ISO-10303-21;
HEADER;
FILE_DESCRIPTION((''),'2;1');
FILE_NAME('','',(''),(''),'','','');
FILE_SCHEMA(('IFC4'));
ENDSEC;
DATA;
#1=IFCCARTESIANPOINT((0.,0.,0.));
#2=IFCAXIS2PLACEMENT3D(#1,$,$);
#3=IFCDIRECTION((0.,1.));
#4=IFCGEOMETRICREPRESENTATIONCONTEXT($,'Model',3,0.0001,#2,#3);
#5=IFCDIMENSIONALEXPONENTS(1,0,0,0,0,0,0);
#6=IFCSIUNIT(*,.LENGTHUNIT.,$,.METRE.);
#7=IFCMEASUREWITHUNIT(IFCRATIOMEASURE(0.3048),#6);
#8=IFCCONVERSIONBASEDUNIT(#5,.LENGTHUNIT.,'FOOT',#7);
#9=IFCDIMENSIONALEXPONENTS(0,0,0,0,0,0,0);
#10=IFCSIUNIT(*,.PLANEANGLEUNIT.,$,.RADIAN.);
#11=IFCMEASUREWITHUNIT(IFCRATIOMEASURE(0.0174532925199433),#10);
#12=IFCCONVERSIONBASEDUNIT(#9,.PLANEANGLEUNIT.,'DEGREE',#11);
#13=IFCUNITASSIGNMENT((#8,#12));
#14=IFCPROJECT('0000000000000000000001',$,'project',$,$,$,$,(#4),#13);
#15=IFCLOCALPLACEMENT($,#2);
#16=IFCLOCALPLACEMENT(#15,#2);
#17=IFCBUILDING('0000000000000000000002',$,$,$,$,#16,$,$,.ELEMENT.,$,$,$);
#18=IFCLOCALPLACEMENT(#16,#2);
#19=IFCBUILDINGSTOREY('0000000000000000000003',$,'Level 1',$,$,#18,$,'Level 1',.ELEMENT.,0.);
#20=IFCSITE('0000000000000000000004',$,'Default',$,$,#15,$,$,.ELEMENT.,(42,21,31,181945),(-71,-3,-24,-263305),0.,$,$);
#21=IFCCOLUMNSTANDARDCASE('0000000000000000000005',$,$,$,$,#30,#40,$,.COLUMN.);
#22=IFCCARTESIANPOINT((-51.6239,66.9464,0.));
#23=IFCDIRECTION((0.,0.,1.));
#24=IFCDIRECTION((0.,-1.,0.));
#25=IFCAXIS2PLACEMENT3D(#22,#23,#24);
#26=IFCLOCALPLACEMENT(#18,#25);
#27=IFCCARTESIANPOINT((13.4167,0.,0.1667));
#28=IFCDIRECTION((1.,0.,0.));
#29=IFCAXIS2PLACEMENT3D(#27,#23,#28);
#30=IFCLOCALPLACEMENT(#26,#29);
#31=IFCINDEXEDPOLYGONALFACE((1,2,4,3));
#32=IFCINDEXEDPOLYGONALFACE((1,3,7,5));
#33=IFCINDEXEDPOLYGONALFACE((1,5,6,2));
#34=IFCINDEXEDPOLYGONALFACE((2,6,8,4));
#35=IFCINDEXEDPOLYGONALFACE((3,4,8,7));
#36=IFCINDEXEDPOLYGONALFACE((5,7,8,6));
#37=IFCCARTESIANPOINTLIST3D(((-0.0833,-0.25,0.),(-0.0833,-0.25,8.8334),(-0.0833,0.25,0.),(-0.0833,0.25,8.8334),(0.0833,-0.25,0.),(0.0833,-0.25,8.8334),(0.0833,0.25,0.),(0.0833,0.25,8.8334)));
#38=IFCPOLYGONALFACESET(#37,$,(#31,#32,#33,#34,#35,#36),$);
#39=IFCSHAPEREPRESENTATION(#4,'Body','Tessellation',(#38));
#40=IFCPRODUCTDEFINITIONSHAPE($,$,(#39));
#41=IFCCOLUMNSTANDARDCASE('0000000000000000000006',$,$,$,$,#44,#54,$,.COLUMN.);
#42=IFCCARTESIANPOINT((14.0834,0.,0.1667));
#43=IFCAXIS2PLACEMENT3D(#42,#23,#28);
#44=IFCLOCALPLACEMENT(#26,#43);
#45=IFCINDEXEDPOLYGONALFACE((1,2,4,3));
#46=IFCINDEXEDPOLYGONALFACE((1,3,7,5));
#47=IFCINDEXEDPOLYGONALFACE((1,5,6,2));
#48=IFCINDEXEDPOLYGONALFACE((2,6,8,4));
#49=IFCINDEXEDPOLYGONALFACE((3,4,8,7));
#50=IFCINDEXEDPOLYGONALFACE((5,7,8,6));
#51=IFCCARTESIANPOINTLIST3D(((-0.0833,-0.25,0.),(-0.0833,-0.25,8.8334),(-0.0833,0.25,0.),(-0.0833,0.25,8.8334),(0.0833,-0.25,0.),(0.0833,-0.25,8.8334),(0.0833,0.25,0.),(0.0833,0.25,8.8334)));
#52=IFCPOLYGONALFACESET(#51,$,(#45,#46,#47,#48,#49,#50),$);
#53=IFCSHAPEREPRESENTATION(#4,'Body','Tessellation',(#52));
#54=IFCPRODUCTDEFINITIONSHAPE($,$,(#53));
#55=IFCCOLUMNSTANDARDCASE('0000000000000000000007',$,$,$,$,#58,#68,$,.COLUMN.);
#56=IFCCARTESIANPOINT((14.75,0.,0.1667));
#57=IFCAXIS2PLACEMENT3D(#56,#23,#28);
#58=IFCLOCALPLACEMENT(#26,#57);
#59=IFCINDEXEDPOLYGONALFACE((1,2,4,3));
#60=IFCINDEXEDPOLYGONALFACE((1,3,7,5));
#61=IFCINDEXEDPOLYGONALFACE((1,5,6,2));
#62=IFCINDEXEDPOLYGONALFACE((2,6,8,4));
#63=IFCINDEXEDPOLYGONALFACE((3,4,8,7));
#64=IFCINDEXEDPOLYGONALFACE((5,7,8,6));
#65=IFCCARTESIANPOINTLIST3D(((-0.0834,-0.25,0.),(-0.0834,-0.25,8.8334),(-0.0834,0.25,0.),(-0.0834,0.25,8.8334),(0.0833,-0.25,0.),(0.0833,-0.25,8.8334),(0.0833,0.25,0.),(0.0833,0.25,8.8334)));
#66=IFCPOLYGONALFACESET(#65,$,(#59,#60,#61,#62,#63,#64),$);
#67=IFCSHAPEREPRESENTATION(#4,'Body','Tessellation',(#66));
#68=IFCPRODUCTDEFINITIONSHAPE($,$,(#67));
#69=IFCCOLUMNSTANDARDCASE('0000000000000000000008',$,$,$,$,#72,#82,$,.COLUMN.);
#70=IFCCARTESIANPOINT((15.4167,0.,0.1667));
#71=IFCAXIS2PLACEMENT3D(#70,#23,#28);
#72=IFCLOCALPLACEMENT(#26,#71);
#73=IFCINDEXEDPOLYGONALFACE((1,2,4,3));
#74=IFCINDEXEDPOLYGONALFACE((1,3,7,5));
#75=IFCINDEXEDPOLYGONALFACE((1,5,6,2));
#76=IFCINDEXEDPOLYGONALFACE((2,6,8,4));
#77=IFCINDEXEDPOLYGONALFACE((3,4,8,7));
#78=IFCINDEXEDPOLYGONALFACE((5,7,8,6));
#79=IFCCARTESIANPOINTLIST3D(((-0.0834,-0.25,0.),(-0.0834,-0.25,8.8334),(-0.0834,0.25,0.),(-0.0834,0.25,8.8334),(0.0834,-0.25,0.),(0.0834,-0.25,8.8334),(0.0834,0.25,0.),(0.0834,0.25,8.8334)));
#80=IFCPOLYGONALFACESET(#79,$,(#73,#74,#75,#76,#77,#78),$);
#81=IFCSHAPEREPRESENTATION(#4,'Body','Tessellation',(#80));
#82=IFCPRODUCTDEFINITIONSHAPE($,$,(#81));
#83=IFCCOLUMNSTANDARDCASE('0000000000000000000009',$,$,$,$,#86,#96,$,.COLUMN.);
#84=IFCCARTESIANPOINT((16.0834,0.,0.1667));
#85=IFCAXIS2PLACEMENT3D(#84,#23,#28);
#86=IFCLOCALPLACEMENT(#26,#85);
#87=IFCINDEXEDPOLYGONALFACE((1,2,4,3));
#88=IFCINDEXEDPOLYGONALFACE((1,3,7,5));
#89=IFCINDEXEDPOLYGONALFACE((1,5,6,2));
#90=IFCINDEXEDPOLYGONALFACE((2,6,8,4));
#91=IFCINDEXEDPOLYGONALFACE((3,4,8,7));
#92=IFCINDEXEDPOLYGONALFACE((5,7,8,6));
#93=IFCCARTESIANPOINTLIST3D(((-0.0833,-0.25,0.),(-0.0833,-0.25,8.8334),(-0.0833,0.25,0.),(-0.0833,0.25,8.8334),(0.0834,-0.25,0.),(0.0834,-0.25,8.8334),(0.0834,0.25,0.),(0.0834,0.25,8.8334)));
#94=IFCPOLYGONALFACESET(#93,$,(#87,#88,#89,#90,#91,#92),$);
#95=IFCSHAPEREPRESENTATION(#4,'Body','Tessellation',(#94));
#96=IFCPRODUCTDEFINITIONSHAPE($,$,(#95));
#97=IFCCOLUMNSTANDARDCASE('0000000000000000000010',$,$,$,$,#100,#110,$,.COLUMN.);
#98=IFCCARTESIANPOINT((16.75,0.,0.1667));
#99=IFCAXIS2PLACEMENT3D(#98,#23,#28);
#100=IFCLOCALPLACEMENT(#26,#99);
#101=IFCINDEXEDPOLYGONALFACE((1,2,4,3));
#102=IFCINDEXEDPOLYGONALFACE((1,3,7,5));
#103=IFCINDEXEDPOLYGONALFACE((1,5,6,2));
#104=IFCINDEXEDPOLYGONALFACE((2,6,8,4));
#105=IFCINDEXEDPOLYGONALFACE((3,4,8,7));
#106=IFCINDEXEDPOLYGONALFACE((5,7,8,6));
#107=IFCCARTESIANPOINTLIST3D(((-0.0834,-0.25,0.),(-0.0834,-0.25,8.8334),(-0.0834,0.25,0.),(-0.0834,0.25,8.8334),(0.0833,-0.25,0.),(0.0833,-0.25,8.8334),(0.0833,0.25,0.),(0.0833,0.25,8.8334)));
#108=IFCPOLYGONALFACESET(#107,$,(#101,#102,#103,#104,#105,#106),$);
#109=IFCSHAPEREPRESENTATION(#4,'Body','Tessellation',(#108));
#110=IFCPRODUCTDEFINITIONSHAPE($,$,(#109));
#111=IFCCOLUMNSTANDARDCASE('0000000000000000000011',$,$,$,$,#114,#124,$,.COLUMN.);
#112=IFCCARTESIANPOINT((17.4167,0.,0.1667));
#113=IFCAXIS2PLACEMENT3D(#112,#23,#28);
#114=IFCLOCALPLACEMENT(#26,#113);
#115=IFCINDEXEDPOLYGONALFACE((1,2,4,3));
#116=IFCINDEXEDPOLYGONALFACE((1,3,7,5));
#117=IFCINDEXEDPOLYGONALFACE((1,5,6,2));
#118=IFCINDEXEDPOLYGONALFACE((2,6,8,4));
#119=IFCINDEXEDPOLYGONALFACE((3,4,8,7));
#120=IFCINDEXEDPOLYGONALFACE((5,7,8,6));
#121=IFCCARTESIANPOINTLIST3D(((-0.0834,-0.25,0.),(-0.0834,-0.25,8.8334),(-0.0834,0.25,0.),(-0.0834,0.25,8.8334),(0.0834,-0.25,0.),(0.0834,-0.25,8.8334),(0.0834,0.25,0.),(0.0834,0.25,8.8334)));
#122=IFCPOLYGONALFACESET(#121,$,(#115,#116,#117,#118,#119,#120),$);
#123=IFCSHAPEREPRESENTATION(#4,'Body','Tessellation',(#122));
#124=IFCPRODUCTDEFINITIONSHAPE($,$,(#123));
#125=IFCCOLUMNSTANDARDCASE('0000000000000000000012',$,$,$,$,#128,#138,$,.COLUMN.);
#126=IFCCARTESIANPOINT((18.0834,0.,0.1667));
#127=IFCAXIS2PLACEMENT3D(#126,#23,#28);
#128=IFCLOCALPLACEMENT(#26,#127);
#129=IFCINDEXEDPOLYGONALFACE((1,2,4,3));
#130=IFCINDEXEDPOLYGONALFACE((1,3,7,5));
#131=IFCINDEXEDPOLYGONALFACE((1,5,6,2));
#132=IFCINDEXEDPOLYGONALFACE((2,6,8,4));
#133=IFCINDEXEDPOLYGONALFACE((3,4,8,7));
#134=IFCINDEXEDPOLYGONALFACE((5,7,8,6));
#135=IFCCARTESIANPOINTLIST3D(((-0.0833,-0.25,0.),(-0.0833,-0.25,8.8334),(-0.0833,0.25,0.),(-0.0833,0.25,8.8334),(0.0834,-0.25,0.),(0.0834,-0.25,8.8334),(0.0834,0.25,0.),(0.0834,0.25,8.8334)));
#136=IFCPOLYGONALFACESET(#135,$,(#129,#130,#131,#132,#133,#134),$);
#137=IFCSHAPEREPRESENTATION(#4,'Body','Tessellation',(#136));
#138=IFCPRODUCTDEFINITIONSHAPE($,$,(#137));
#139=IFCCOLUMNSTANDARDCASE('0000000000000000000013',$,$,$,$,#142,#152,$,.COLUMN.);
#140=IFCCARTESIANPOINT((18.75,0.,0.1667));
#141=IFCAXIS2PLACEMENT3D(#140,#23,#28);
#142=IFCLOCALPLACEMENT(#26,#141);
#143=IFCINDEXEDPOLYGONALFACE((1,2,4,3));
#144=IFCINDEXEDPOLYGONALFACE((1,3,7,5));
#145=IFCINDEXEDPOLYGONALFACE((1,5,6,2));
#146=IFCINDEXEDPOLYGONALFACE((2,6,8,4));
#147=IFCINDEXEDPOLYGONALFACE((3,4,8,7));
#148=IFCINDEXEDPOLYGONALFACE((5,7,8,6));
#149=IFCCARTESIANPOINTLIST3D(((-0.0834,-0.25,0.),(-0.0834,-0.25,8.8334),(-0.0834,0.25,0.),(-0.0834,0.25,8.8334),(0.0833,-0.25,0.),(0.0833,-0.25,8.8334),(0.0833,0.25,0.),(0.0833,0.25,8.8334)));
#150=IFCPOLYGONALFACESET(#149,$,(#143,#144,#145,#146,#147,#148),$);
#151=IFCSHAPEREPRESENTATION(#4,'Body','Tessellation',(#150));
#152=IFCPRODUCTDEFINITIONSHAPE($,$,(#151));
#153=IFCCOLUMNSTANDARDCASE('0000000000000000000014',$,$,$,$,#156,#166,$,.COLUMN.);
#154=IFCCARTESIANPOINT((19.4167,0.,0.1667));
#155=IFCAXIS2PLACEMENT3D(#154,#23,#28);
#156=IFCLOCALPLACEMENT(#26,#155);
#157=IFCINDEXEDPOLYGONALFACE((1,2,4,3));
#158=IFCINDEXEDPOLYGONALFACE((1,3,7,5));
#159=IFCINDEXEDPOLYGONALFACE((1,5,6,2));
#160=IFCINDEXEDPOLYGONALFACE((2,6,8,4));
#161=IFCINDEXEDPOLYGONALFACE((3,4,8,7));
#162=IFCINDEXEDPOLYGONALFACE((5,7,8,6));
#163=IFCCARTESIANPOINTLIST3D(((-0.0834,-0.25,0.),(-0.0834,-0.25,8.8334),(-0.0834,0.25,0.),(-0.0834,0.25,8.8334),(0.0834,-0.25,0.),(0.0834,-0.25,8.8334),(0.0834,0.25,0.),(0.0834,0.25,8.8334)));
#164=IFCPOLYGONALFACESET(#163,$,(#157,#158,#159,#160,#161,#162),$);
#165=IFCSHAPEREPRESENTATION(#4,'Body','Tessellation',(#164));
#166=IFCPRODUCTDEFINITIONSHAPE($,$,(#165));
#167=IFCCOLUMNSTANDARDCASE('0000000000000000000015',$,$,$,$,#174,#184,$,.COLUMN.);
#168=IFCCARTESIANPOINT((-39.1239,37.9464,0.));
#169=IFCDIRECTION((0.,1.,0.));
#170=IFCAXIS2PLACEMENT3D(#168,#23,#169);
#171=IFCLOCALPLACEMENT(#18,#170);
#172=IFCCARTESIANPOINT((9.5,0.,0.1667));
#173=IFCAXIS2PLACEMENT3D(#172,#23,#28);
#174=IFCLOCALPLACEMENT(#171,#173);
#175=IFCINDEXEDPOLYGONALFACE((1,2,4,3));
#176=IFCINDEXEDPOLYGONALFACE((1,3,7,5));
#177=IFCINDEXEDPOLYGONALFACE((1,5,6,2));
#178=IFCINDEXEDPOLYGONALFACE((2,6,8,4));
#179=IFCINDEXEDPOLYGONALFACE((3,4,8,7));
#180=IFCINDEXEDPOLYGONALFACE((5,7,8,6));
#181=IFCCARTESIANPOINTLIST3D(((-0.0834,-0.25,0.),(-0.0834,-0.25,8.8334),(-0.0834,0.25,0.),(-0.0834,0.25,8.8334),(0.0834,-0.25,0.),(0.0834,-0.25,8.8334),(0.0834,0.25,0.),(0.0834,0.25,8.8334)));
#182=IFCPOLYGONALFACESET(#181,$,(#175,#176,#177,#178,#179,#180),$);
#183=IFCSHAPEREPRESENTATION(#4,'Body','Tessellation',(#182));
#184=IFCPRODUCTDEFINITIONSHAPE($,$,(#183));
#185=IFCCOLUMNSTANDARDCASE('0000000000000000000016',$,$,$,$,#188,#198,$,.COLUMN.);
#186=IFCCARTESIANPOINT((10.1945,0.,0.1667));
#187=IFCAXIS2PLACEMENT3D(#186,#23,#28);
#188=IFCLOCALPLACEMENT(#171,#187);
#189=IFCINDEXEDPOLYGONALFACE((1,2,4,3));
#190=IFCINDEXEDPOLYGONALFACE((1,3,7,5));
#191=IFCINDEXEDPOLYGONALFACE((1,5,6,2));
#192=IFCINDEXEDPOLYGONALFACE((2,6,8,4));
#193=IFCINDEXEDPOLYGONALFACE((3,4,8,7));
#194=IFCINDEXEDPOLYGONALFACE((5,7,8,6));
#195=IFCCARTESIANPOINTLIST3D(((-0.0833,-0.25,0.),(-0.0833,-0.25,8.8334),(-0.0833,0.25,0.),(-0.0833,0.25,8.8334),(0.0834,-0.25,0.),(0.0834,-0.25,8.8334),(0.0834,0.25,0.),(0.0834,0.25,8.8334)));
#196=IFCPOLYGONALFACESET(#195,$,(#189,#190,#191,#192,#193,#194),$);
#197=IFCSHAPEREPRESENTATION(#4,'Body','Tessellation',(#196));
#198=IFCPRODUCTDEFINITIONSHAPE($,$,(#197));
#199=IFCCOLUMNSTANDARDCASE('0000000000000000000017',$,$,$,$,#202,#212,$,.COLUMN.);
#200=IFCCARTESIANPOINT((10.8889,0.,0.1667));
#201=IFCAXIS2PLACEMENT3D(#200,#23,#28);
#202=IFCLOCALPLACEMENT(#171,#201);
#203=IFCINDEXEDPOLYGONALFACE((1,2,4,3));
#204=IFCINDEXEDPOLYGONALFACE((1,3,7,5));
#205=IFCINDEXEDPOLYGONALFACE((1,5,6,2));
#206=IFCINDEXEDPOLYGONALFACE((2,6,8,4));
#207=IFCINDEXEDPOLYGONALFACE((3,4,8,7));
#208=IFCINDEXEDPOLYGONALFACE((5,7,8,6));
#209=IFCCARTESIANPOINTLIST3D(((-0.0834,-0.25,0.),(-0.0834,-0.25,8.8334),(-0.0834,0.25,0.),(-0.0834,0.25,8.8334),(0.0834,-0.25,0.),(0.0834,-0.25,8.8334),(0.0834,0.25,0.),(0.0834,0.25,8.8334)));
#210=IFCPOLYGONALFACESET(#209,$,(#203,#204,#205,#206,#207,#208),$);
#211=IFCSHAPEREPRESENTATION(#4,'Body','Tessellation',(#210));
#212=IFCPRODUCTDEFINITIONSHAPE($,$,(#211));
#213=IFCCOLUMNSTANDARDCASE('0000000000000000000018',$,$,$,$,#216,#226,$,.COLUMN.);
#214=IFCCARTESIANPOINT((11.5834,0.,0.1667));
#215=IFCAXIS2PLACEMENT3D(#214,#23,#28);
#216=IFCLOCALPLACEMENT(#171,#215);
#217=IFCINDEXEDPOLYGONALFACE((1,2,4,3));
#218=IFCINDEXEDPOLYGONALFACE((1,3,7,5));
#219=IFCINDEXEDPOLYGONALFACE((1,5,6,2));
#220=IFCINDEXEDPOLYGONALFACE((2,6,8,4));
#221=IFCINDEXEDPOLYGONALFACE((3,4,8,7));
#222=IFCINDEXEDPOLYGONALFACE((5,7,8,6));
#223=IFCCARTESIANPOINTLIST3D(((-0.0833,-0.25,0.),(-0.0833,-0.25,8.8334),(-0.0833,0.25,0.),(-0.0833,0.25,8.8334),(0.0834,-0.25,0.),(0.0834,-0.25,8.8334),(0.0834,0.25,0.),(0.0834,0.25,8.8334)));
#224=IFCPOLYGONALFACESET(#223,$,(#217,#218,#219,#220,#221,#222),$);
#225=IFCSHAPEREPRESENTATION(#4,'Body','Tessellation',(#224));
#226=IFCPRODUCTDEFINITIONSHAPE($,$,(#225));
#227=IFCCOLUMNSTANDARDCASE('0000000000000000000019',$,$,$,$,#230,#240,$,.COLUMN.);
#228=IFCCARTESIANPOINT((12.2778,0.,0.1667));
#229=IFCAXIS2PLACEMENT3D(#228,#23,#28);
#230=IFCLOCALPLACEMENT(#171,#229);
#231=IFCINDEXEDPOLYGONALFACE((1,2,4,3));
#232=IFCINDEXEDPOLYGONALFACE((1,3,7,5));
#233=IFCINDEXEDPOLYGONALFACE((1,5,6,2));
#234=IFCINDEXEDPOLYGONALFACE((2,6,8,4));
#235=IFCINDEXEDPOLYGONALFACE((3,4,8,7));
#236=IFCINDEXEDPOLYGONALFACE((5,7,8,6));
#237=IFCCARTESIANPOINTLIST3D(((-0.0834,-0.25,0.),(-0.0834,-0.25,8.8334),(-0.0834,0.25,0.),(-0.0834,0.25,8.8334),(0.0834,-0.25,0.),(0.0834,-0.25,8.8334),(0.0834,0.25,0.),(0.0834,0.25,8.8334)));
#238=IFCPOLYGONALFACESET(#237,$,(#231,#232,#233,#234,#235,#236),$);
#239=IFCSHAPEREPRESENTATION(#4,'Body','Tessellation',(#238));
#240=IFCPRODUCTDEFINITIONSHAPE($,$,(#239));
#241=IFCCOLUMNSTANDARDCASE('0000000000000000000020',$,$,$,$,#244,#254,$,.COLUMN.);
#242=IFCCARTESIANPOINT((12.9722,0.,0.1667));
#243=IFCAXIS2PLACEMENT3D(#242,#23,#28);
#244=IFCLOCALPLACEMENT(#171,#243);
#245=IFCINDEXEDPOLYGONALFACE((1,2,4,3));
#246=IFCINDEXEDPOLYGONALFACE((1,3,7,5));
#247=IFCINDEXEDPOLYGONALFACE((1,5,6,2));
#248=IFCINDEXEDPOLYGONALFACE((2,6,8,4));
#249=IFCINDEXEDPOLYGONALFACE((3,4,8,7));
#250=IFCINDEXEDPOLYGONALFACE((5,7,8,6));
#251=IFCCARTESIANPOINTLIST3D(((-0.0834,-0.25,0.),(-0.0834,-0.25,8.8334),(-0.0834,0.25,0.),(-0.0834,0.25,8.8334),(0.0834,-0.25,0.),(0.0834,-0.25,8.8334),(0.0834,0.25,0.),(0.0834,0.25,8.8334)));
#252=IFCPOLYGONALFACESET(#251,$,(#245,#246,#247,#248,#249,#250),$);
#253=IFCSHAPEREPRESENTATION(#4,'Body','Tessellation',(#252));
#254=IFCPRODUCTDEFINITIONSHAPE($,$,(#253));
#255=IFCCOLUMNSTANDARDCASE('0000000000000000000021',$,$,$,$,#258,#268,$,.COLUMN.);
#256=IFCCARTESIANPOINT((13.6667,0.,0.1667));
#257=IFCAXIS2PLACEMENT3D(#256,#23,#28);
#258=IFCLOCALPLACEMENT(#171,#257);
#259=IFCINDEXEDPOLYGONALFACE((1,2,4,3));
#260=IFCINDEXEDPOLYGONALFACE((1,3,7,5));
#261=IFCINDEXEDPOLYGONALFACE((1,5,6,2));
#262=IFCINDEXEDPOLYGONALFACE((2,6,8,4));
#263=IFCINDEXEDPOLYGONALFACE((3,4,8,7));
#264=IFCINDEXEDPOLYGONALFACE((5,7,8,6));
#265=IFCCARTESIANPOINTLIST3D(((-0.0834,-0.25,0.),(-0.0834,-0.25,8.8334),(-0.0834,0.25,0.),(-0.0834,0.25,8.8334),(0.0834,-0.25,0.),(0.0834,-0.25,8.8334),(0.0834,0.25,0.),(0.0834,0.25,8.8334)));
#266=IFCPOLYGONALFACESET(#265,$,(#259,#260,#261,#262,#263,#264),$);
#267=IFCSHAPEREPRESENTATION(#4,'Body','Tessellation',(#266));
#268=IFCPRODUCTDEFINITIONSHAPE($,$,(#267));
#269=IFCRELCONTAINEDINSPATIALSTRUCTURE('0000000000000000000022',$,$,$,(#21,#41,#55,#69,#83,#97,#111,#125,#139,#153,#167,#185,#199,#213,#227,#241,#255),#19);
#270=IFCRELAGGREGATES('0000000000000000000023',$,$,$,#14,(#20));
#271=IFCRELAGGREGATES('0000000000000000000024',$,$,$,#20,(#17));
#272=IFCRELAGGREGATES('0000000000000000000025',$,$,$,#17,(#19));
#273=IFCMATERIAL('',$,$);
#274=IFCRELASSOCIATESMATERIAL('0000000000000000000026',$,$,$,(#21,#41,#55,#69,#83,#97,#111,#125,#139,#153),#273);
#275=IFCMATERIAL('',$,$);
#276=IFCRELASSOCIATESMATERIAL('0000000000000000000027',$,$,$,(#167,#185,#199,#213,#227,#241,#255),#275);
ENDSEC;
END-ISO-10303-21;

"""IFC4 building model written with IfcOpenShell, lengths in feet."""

from ifc_helpers import new_model, entity, si_unit, converted_unit, direction, frame, origin, place, context, project, spatial, rectangle, extrude, material, element, save


model = new_model("IFC4")

# Units and contexts
model_context = context("Model", 3, precision=0.0001, world=origin(), true_north=direction((0.0, 1.0)))
ifc_project = project(units=[converted_unit("LENGTHUNIT", "FOOT", entity("IfcRatioMeasure", 0.3048), si_unit("LENGTHUNIT", "METRE"), dimensions=[1, 0, 0, 0, 0, 0, 0]), converted_unit("PLANEANGLEUNIT", "DEGREE", entity("IfcRatioMeasure", 0.0174532925199433), si_unit("PLANEANGLEUNIT", "RADIAN"), dimensions=[0, 0, 0, 0, 0, 0, 0])], contexts=[model_context])

# Site, building, storey
site_placement = place(None, origin())
site = spatial("IfcSite", under=ifc_project, at=site_placement, Name="Default", CompositionType="ELEMENT", RefLatitude=(42, 21, 31, 181945), RefLongitude=(-71, -3, -24, -263305), RefElevation=0.0)
building_placement = place(site_placement, origin())
building = spatial("IfcBuilding", under=site, at=building_placement, CompositionType="ELEMENT")
storey_placement = place(building_placement, origin())
storey = spatial("IfcBuildingStorey", under=building, at=storey_placement, Name="Level 1", LongName="Level 1", CompositionType="ELEMENT", Elevation=0.0)

# Columns
ifc_material_1 = material(Name="")
placement_1 = place(storey_placement, frame((-51.6239, 66.9464, 0.0), z_axis=(0.0, 0.0, 1.0), x_axis=(0.0, -1.0, 0.0)))
for number, where, z_axis, x_axis in (
    (1, (13.4167, 0.0, 0.1667), (0.0, 0.0, 1.0), (1.0, 0.0, 0.0)),
    (2, (14.0834, 0.0, 0.1667), (0.0, 0.0, 1.0), (1.0, 0.0, 0.0)),
    (3, (14.75, 0.0, 0.1667), (0.0, 0.0, 1.0), (1.0, 0.0, 0.0)),
    (4, (15.4167, 0.0, 0.1667), (0.0, 0.0, 1.0), (1.0, 0.0, 0.0)),
    (5, (16.0834, 0.0, 0.1667), (0.0, 0.0, 1.0), (1.0, 0.0, 0.0)),
    (6, (16.75, 0.0, 0.1667), (0.0, 0.0, 1.0), (1.0, 0.0, 0.0)),
    (7, (17.4167, 0.0, 0.1667), (0.0, 0.0, 1.0), (1.0, 0.0, 0.0)),
    (8, (18.0834, 0.0, 0.1667), (0.0, 0.0, 1.0), (1.0, 0.0, 0.0)),
    (9, (18.75, 0.0, 0.1667), (0.0, 0.0, 1.0), (1.0, 0.0, 0.0)),
    (10, (19.4167, 0.0, 0.1667), (0.0, 0.0, 1.0), (1.0, 0.0, 0.0)),
):
    element("IfcColumnStandardCase", number, at=place(placement_1, frame(where, z_axis=z_axis, x_axis=x_axis)), inside=storey, material=ifc_material_1, PredefinedType="COLUMN", context=model_context, shape_type="SweptSolid", body=[
        extrude(rectangle(XDim=0.1667, YDim=0.5), origin(), (0.0, 0.0, 1.0), 8.8334),
    ])
ifc_material_2 = material(Name="")
placement_2 = place(storey_placement, frame((-39.1239, 37.9464, 0.0), z_axis=(0.0, 0.0, 1.0), x_axis=(0.0, 1.0, 0.0)))
for number, where, z_axis, x_axis in (
    (11, (9.5, 0.0, 0.1667), (0.0, 0.0, 1.0), (1.0, 0.0, 0.0)),
    (12, (10.1945, 0.0, 0.1667), (0.0, 0.0, 1.0), (1.0, 0.0, 0.0)),
    (13, (10.8889, 0.0, 0.1667), (0.0, 0.0, 1.0), (1.0, 0.0, 0.0)),
    (14, (11.5834, 0.0, 0.1667), (0.0, 0.0, 1.0), (1.0, 0.0, 0.0)),
    (15, (12.2778, 0.0, 0.1667), (0.0, 0.0, 1.0), (1.0, 0.0, 0.0)),
    (16, (12.9722, 0.0, 0.1667), (0.0, 0.0, 1.0), (1.0, 0.0, 0.0)),
    (17, (13.6667, 0.0, 0.1667), (0.0, 0.0, 1.0), (1.0, 0.0, 0.0)),
):
    element("IfcColumnStandardCase", number, at=place(placement_2, frame(where, z_axis=z_axis, x_axis=x_axis)), inside=storey, material=ifc_material_2, PredefinedType="COLUMN", context=model_context, shape_type="SweptSolid", body=[
        extrude(rectangle(XDim=0.1667, YDim=0.5), origin(), (0.0, 0.0, 1.0), 8.8334),
    ])

save(model, "model.ifc")
